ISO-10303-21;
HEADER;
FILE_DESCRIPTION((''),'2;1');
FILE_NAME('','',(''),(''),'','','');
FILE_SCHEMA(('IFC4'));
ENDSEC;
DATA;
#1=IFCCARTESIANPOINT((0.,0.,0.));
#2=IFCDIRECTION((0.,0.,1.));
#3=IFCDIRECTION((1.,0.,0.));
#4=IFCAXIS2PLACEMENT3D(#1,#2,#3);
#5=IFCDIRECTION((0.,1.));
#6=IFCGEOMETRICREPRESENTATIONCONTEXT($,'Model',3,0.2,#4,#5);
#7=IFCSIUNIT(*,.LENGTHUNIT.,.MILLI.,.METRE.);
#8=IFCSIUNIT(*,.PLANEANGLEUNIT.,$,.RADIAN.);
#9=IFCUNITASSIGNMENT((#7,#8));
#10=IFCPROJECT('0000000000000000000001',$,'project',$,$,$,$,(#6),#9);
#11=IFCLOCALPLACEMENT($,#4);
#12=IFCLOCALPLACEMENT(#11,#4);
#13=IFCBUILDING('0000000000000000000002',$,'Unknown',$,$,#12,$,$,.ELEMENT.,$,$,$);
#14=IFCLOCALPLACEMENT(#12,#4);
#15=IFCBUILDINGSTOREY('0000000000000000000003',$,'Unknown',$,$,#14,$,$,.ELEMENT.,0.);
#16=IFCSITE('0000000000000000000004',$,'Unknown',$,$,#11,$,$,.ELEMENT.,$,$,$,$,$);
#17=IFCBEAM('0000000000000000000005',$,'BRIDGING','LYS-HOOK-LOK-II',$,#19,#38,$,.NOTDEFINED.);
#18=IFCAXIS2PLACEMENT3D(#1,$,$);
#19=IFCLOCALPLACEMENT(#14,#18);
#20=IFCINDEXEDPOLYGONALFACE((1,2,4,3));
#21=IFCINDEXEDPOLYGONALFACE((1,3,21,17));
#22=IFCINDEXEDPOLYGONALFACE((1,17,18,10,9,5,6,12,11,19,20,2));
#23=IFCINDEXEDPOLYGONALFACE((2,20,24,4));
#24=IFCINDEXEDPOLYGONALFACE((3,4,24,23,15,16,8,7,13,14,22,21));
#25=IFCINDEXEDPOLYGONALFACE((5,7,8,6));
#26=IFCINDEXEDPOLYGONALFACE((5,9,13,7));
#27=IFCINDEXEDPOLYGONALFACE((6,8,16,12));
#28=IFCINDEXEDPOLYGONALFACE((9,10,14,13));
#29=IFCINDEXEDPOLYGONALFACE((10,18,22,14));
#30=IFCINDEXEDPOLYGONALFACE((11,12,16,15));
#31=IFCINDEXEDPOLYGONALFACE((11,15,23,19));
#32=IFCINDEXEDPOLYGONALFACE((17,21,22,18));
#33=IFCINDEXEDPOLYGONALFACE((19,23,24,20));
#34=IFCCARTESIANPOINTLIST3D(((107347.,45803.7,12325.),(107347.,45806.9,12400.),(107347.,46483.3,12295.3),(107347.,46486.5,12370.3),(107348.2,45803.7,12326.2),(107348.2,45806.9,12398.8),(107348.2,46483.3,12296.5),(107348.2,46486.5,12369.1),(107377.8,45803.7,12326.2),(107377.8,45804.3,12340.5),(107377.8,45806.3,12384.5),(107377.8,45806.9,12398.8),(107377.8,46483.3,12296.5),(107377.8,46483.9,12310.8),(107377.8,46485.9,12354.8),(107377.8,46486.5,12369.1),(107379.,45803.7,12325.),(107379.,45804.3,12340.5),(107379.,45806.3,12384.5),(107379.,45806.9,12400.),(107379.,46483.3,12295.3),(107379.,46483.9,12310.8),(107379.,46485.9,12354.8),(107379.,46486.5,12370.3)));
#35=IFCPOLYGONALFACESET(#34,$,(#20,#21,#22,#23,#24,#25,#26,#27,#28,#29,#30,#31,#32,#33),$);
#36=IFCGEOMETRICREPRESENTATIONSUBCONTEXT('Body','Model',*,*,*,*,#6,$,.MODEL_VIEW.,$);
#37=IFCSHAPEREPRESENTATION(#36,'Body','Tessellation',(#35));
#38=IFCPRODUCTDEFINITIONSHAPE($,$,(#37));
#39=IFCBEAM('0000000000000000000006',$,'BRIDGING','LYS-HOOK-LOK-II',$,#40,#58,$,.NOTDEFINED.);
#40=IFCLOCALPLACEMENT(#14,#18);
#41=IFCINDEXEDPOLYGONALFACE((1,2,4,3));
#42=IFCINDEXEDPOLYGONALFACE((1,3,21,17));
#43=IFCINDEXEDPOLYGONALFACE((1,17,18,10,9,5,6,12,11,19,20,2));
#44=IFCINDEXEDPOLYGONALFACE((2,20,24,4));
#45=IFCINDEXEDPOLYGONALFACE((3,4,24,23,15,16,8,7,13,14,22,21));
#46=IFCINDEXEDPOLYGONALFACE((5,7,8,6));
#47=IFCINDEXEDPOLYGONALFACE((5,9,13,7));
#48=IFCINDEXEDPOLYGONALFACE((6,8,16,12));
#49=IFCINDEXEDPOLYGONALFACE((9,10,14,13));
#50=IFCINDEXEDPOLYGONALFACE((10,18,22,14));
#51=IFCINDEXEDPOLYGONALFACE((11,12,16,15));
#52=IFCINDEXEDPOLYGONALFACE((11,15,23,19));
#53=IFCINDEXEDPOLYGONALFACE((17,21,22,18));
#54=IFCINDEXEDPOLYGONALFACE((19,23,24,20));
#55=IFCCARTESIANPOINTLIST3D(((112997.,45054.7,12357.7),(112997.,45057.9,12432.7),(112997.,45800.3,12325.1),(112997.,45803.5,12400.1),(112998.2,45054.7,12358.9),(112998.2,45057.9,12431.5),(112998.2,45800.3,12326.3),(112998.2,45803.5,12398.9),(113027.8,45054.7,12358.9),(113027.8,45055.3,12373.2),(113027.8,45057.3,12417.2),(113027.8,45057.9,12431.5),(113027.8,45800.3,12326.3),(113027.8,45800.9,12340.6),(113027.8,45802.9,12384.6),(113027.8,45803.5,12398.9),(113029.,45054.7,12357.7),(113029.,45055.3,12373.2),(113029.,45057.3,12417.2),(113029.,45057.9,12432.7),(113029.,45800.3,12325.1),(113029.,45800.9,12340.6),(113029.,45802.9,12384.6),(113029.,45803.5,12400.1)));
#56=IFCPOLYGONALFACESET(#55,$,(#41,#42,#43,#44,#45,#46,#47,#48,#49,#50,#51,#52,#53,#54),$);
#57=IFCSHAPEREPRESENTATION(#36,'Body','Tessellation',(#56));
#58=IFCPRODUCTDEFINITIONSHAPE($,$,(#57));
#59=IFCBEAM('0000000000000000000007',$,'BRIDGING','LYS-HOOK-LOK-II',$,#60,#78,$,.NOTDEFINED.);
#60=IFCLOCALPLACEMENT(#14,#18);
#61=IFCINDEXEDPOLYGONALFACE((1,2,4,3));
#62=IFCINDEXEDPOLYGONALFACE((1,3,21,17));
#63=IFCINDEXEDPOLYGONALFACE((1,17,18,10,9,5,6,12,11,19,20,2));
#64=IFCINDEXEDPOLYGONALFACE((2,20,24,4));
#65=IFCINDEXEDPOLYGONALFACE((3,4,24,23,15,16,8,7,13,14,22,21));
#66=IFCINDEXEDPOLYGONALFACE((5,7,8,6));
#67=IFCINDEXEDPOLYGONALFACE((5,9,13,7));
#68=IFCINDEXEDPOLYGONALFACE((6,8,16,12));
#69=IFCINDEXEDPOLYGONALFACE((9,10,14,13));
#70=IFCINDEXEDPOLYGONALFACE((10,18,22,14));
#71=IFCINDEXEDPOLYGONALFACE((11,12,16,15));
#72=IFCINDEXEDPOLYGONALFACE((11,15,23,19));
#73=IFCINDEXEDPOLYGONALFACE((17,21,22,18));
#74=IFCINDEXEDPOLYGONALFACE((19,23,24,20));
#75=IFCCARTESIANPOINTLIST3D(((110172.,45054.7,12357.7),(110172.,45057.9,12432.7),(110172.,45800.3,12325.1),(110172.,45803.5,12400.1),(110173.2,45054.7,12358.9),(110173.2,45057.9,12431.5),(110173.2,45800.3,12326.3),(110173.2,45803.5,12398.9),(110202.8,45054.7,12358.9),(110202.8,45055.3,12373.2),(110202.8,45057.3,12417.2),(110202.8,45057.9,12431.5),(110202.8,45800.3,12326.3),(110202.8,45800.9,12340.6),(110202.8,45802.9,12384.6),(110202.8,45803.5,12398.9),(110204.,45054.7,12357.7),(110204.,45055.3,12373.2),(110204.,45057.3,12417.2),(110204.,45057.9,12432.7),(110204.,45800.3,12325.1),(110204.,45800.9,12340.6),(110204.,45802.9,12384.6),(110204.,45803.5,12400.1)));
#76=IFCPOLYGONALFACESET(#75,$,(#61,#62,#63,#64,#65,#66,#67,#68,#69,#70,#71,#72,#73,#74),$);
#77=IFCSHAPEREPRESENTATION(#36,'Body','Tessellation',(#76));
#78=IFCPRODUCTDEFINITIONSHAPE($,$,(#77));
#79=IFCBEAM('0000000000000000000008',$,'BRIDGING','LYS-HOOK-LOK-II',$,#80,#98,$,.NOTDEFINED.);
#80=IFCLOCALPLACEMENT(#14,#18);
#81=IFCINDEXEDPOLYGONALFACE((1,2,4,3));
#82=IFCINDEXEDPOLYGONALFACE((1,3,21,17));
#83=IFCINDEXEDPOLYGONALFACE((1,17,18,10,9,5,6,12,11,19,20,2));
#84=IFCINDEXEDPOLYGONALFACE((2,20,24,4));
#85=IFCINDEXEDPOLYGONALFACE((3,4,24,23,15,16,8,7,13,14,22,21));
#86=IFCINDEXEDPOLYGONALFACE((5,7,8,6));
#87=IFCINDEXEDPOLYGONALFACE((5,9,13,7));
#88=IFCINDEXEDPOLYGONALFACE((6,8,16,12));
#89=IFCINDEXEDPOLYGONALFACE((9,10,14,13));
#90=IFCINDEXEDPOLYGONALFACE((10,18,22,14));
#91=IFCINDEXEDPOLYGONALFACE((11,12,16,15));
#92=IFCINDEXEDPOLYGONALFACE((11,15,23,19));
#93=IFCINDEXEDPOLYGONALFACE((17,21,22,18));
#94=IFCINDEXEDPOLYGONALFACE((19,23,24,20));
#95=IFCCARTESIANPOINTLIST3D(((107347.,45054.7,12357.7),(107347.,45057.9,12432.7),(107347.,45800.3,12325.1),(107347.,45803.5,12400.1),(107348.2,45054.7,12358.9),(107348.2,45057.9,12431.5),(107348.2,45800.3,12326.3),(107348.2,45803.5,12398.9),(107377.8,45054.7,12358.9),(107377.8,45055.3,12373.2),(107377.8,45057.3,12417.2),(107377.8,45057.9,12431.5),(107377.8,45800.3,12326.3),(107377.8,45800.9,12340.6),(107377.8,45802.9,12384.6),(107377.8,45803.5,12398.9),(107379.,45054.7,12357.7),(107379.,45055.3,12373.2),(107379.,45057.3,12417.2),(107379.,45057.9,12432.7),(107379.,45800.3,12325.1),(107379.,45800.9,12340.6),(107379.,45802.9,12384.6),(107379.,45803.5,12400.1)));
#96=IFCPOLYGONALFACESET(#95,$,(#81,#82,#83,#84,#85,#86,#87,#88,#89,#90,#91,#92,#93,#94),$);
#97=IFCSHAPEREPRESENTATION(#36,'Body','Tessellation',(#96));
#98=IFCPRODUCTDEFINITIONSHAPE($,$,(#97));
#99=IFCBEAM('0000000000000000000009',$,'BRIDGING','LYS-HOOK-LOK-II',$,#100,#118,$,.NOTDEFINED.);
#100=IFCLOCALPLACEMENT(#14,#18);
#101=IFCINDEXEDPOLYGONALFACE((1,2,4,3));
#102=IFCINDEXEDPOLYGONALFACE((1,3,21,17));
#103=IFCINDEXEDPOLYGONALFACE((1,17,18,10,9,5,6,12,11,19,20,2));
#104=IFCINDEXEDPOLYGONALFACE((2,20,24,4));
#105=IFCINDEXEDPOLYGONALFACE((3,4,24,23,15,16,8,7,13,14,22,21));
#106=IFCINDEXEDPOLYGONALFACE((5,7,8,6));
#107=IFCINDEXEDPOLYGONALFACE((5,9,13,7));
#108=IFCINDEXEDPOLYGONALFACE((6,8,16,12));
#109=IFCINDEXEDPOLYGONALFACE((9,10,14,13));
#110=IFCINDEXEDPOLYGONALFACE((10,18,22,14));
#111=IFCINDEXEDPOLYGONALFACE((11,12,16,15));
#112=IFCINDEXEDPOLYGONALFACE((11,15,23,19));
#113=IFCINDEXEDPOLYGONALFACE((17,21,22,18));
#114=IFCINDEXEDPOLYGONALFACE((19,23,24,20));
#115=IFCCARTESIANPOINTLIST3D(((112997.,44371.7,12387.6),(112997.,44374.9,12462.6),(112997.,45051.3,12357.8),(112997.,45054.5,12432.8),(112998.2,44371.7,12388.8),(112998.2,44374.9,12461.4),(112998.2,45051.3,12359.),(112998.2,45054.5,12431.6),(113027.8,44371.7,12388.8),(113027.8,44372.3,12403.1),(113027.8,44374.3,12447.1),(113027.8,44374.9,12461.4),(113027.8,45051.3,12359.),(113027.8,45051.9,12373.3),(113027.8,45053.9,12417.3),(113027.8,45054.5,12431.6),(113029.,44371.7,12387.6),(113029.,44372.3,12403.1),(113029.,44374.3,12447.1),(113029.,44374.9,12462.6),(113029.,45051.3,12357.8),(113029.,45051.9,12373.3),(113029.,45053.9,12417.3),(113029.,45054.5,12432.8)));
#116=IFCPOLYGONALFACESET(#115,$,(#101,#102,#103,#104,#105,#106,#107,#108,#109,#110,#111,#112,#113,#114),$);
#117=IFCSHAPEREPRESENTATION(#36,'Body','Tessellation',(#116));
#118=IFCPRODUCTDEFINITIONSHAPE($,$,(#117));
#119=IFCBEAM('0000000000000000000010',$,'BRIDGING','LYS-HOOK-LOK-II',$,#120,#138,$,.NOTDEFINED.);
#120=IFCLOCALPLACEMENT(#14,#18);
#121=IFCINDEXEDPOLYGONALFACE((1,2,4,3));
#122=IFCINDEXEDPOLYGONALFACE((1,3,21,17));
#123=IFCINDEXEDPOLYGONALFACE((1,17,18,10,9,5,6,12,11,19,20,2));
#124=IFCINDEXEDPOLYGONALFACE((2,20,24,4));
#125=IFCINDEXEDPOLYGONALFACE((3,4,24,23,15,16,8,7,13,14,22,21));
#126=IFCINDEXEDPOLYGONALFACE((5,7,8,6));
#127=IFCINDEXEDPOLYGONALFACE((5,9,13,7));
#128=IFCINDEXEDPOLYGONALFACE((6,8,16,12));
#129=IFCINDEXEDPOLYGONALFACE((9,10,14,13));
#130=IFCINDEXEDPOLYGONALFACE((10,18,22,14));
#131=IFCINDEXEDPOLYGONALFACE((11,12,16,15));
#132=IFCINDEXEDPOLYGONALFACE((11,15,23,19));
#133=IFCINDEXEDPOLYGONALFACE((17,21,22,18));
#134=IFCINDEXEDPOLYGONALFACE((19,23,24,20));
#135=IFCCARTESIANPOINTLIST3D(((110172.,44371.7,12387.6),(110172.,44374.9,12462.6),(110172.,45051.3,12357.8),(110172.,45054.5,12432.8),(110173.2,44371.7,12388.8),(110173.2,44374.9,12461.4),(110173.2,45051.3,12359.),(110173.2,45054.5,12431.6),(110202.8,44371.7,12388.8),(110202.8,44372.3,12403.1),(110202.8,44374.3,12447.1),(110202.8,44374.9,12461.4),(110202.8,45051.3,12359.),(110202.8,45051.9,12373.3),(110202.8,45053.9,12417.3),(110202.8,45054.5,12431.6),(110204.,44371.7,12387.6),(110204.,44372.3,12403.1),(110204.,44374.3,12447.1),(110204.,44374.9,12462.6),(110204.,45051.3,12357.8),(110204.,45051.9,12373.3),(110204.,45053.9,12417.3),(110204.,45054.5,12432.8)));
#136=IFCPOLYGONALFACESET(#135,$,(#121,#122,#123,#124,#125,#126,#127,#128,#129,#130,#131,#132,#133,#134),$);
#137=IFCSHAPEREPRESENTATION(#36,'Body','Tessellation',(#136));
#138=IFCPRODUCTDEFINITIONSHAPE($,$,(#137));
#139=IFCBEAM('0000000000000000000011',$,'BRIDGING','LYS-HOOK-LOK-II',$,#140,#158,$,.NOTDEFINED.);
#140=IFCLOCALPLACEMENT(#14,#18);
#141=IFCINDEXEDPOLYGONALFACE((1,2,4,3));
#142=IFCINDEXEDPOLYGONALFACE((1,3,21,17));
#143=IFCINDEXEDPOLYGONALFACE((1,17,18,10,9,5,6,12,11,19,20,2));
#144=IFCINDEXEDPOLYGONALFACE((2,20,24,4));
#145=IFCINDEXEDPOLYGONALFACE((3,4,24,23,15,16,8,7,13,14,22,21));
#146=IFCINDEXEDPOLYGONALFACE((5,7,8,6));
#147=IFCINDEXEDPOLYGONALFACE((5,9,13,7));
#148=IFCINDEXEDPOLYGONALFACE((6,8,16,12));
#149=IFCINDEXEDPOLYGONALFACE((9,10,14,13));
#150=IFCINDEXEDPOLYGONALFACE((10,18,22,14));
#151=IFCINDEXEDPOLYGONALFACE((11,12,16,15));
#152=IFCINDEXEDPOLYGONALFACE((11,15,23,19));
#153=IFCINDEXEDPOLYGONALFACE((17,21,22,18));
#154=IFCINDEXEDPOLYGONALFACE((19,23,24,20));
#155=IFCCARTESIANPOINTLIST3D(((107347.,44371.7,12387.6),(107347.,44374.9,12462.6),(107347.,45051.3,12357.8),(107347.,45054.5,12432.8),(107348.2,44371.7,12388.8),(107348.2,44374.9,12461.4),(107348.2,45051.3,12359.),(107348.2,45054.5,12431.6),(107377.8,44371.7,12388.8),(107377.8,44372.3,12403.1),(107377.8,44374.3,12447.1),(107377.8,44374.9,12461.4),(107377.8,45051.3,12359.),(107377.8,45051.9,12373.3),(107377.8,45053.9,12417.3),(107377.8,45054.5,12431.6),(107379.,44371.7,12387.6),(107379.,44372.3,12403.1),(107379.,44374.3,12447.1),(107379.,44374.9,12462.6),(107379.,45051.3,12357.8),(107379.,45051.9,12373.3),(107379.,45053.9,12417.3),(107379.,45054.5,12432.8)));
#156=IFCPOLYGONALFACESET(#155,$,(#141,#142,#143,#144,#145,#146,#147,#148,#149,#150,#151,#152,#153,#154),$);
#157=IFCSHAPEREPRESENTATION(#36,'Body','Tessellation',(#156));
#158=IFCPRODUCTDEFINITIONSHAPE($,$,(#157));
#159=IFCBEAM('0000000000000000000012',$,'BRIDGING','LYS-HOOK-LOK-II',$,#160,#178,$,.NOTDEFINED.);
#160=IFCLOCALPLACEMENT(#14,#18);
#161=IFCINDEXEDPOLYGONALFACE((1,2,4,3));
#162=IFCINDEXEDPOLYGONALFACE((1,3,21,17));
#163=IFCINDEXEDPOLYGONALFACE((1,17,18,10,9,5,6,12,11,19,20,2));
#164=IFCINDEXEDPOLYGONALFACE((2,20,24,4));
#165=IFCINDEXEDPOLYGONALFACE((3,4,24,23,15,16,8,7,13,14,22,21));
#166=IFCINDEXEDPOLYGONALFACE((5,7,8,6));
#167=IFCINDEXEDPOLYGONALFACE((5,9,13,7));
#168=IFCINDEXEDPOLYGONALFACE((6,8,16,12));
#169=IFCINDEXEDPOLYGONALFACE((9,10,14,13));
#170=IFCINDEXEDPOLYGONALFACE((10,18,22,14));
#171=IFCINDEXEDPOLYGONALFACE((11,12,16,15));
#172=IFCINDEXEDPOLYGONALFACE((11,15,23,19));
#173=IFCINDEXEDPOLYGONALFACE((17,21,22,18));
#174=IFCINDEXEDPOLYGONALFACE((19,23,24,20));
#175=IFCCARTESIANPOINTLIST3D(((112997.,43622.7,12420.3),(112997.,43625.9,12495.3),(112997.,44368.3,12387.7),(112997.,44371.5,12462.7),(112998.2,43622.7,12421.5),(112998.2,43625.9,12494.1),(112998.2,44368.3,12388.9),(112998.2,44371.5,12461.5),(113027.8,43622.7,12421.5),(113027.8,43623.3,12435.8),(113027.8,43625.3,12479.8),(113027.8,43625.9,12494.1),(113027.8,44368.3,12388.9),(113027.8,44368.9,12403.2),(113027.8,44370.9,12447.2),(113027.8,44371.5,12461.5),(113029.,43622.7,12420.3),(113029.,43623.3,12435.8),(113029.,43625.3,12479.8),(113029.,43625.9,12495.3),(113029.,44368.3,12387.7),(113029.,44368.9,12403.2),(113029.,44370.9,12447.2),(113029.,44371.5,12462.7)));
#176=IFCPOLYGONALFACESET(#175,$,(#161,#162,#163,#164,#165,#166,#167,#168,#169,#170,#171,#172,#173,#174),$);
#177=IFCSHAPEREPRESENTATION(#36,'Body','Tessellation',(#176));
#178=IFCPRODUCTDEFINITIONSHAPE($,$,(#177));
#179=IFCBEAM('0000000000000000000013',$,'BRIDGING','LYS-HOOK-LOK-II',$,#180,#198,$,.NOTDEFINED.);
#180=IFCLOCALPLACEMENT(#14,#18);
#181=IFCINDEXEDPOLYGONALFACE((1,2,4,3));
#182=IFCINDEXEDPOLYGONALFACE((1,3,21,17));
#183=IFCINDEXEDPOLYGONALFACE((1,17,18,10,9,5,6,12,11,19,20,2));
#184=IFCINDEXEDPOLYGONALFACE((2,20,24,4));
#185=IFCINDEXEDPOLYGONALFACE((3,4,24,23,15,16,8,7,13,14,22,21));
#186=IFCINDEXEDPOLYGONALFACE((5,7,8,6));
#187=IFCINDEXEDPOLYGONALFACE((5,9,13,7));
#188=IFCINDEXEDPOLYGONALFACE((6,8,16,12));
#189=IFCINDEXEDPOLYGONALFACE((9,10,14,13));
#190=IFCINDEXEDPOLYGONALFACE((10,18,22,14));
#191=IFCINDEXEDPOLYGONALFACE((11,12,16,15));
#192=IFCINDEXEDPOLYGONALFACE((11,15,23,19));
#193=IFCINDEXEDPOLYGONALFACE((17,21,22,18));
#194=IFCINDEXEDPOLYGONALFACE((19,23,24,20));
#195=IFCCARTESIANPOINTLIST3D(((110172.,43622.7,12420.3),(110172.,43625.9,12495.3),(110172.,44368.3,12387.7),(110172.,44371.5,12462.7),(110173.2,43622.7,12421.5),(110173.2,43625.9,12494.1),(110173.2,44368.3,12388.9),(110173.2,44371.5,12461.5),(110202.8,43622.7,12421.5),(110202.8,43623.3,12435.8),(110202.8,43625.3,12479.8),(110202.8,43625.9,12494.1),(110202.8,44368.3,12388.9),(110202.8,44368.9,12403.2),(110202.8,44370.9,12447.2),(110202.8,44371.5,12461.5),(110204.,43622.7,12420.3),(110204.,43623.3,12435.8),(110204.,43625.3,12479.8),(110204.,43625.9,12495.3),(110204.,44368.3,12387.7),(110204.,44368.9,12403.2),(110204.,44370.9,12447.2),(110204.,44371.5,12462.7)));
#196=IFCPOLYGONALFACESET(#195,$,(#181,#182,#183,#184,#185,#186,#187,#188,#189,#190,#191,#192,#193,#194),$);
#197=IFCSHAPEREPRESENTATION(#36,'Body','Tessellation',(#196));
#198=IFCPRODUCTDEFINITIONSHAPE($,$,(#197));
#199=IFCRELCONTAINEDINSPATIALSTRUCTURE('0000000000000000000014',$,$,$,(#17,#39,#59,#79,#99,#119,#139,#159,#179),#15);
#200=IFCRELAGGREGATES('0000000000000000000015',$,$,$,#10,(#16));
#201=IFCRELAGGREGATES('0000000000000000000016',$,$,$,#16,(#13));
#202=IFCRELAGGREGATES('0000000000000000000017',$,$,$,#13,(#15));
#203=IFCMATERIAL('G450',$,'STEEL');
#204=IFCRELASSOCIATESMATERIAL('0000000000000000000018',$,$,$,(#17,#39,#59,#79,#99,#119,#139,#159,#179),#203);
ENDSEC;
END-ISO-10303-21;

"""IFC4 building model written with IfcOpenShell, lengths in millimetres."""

from ifc_helpers import new_model, si_unit, direction, frame, origin_with_axes, place, context, subcontext, project, spatial, line, indexed_curve, outline, extrude, material, element, save


model = new_model("IFC4")

# Units and contexts
model_context = context("Model", 3, precision=0.2, world=origin_with_axes(), true_north=direction((0.0, 1.0)))
body_context = subcontext(model_context, "Body", "Model", "MODEL_VIEW")
ifc_project = project(units=[si_unit("LENGTHUNIT", "METRE", prefix="MILLI"), si_unit("PLANEANGLEUNIT", "RADIAN")], contexts=[model_context])

# Site, building, storey
site_placement = place(None, origin_with_axes())
site = spatial("IfcSite", under=ifc_project, at=site_placement, Name="Unknown", CompositionType="ELEMENT")
building_placement = place(site_placement, origin_with_axes())
building = spatial("IfcBuilding", under=site, at=building_placement, Name="Unknown", CompositionType="ELEMENT")
storey_placement = place(building_placement, origin_with_axes())
storey = spatial("IfcBuildingStorey", under=building, at=storey_placement, Name="Unknown", CompositionType="ELEMENT", Elevation=0.0)

# Beams
ifc_material_1 = material(Name="G450", Category="STEEL")
for number, where, z_axis, x_axis, name in (
    (1, (107363.0, 45805.3, 12362.5), (1.0, 0.0, 0.0), (0.0, 0.999046, -0.043661), "BRIDGING"),
):
    element("IfcBeam", number, at=place(storey_placement, frame(where, z_axis=z_axis, x_axis=x_axis)), inside=storey, material=ifc_material_1, Name=name, Description="LYS-HOOK-LOK-II", PredefinedType="NOTDEFINED", context=body_context, shape_type="SolidModel", body=[
        extrude(outline(indexed_curve([(16.0, -37.5), (16.0, -22.0), (14.8, -22.0), (14.8, -36.3), (-14.8, -36.3), (-14.8, 36.3), (14.8, 36.3), (14.8, 22.0), (16.0, 22.0), (16.0, 37.5), (-16.0, 37.5), (-16.0, -37.5)], segments=[line(1, 2, 3, 4, 5, 6, 7, 8, 9, 10, 11, 12, 1)])), frame((0.0, 0.0, 0.0), z_axis=(-1.0, 0.0, 0.0), x_axis=(0.0, 0.0, 1.0)), (0.0, 0.0, -1.0), 680.2),
    ])
for number, where, z_axis, x_axis, name in (
    (2, (113013.0, 45056.3, 12395.2), (1.0, 0.0, 0.0), (0.0, 0.999046, -0.043681), "BRIDGING"),
    (3, (110188.0, 45056.3, 12395.2), (1.0, 0.0, 0.0), (0.0, 0.999046, -0.043681), "BRIDGING"),
    (4, (107363.0, 45056.3, 12395.2), (1.0, 0.0, 0.0), (0.0, 0.999046, -0.043681), "BRIDGING"),
):
    element("IfcBeam", number, at=place(storey_placement, frame(where, z_axis=z_axis, x_axis=x_axis)), inside=storey, material=ifc_material_1, Name=name, Description="LYS-HOOK-LOK-II", PredefinedType="NOTDEFINED", context=body_context, shape_type="SolidModel", body=[
        extrude(outline(indexed_curve([(16.0, -37.5), (16.0, -22.0), (14.8, -22.0), (14.8, -36.3), (-14.8, -36.3), (-14.8, 36.3), (14.8, 36.3), (14.8, 22.0), (16.0, 22.0), (16.0, 37.5), (-16.0, 37.5), (-16.0, -37.5)], segments=[line(1, 2, 3, 4, 5, 6, 7, 8, 9, 10, 11, 12, 1)])), frame((0.0, 0.0, 0.0), z_axis=(-1.0, 0.0, 0.0), x_axis=(0.0, 0.0, 1.0)), (0.0, 0.0, -1.0), 746.3),
    ])
for number, where, z_axis, x_axis, name in (
    (5, (113013.0, 44373.3, 12425.1), (1.0, 0.0, 0.0), (0.0, 0.99904, -0.043807), "BRIDGING"),
    (6, (110188.0, 44373.3, 12425.1), (1.0, 0.0, 0.0), (0.0, 0.99904, -0.043807), "BRIDGING"),
    (7, (107363.0, 44373.3, 12425.1), (1.0, 0.0, 0.0), (0.0, 0.99904, -0.043807), "BRIDGING"),
):
    element("IfcBeam", number, at=place(storey_placement, frame(where, z_axis=z_axis, x_axis=x_axis)), inside=storey, material=ifc_material_1, Name=name, Description="LYS-HOOK-LOK-II", PredefinedType="NOTDEFINED", context=body_context, shape_type="SolidModel", body=[
        extrude(outline(indexed_curve([(16.0, -37.5), (16.0, -22.0), (14.8, -22.0), (14.8, -36.3), (-14.8, -36.3), (-14.8, 36.3), (14.8, 36.3), (14.8, 22.0), (16.0, 22.0), (16.0, 37.5), (-16.0, 37.5), (-16.0, -37.5)], segments=[line(1, 2, 3, 4, 5, 6, 7, 8, 9, 10, 11, 12, 1)])), frame((0.0, 0.0, 0.0), z_axis=(-1.0, 0.0, 0.0), x_axis=(0.0, 0.0, 1.0)), (0.0, 0.0, -1.0), 680.3),
    ])
for number, where, z_axis, x_axis, name in (
    (8, (113013.0, 43624.3, 12457.8), (1.0, 0.0, 0.0), (0.0, 0.999046, -0.043681), "BRIDGING"),
    (9, (110188.0, 43624.3, 12457.8), (1.0, 0.0, 0.0), (0.0, 0.999046, -0.043681), "BRIDGING"),
):
    element("IfcBeam", number, at=place(storey_placement, frame(where, z_axis=z_axis, x_axis=x_axis)), inside=storey, material=ifc_material_1, Name=name, Description="LYS-HOOK-LOK-II", PredefinedType="NOTDEFINED", context=body_context, shape_type="SolidModel", body=[
        extrude(outline(indexed_curve([(16.0, -37.5), (16.0, -22.0), (14.8, -22.0), (14.8, -36.3), (-14.8, -36.3), (-14.8, 36.3), (14.8, 36.3), (14.8, 22.0), (16.0, 22.0), (16.0, 37.5), (-16.0, 37.5), (-16.0, -37.5)], segments=[line(1, 2, 3, 4, 5, 6, 7, 8, 9, 10, 11, 12, 1)])), frame((0.0, 0.0, 0.0), z_axis=(-1.0, 0.0, 0.0), x_axis=(0.0, 0.0, 1.0)), (0.0, 0.0, -1.0), 746.3),
    ])

save(model, "model.ifc")
